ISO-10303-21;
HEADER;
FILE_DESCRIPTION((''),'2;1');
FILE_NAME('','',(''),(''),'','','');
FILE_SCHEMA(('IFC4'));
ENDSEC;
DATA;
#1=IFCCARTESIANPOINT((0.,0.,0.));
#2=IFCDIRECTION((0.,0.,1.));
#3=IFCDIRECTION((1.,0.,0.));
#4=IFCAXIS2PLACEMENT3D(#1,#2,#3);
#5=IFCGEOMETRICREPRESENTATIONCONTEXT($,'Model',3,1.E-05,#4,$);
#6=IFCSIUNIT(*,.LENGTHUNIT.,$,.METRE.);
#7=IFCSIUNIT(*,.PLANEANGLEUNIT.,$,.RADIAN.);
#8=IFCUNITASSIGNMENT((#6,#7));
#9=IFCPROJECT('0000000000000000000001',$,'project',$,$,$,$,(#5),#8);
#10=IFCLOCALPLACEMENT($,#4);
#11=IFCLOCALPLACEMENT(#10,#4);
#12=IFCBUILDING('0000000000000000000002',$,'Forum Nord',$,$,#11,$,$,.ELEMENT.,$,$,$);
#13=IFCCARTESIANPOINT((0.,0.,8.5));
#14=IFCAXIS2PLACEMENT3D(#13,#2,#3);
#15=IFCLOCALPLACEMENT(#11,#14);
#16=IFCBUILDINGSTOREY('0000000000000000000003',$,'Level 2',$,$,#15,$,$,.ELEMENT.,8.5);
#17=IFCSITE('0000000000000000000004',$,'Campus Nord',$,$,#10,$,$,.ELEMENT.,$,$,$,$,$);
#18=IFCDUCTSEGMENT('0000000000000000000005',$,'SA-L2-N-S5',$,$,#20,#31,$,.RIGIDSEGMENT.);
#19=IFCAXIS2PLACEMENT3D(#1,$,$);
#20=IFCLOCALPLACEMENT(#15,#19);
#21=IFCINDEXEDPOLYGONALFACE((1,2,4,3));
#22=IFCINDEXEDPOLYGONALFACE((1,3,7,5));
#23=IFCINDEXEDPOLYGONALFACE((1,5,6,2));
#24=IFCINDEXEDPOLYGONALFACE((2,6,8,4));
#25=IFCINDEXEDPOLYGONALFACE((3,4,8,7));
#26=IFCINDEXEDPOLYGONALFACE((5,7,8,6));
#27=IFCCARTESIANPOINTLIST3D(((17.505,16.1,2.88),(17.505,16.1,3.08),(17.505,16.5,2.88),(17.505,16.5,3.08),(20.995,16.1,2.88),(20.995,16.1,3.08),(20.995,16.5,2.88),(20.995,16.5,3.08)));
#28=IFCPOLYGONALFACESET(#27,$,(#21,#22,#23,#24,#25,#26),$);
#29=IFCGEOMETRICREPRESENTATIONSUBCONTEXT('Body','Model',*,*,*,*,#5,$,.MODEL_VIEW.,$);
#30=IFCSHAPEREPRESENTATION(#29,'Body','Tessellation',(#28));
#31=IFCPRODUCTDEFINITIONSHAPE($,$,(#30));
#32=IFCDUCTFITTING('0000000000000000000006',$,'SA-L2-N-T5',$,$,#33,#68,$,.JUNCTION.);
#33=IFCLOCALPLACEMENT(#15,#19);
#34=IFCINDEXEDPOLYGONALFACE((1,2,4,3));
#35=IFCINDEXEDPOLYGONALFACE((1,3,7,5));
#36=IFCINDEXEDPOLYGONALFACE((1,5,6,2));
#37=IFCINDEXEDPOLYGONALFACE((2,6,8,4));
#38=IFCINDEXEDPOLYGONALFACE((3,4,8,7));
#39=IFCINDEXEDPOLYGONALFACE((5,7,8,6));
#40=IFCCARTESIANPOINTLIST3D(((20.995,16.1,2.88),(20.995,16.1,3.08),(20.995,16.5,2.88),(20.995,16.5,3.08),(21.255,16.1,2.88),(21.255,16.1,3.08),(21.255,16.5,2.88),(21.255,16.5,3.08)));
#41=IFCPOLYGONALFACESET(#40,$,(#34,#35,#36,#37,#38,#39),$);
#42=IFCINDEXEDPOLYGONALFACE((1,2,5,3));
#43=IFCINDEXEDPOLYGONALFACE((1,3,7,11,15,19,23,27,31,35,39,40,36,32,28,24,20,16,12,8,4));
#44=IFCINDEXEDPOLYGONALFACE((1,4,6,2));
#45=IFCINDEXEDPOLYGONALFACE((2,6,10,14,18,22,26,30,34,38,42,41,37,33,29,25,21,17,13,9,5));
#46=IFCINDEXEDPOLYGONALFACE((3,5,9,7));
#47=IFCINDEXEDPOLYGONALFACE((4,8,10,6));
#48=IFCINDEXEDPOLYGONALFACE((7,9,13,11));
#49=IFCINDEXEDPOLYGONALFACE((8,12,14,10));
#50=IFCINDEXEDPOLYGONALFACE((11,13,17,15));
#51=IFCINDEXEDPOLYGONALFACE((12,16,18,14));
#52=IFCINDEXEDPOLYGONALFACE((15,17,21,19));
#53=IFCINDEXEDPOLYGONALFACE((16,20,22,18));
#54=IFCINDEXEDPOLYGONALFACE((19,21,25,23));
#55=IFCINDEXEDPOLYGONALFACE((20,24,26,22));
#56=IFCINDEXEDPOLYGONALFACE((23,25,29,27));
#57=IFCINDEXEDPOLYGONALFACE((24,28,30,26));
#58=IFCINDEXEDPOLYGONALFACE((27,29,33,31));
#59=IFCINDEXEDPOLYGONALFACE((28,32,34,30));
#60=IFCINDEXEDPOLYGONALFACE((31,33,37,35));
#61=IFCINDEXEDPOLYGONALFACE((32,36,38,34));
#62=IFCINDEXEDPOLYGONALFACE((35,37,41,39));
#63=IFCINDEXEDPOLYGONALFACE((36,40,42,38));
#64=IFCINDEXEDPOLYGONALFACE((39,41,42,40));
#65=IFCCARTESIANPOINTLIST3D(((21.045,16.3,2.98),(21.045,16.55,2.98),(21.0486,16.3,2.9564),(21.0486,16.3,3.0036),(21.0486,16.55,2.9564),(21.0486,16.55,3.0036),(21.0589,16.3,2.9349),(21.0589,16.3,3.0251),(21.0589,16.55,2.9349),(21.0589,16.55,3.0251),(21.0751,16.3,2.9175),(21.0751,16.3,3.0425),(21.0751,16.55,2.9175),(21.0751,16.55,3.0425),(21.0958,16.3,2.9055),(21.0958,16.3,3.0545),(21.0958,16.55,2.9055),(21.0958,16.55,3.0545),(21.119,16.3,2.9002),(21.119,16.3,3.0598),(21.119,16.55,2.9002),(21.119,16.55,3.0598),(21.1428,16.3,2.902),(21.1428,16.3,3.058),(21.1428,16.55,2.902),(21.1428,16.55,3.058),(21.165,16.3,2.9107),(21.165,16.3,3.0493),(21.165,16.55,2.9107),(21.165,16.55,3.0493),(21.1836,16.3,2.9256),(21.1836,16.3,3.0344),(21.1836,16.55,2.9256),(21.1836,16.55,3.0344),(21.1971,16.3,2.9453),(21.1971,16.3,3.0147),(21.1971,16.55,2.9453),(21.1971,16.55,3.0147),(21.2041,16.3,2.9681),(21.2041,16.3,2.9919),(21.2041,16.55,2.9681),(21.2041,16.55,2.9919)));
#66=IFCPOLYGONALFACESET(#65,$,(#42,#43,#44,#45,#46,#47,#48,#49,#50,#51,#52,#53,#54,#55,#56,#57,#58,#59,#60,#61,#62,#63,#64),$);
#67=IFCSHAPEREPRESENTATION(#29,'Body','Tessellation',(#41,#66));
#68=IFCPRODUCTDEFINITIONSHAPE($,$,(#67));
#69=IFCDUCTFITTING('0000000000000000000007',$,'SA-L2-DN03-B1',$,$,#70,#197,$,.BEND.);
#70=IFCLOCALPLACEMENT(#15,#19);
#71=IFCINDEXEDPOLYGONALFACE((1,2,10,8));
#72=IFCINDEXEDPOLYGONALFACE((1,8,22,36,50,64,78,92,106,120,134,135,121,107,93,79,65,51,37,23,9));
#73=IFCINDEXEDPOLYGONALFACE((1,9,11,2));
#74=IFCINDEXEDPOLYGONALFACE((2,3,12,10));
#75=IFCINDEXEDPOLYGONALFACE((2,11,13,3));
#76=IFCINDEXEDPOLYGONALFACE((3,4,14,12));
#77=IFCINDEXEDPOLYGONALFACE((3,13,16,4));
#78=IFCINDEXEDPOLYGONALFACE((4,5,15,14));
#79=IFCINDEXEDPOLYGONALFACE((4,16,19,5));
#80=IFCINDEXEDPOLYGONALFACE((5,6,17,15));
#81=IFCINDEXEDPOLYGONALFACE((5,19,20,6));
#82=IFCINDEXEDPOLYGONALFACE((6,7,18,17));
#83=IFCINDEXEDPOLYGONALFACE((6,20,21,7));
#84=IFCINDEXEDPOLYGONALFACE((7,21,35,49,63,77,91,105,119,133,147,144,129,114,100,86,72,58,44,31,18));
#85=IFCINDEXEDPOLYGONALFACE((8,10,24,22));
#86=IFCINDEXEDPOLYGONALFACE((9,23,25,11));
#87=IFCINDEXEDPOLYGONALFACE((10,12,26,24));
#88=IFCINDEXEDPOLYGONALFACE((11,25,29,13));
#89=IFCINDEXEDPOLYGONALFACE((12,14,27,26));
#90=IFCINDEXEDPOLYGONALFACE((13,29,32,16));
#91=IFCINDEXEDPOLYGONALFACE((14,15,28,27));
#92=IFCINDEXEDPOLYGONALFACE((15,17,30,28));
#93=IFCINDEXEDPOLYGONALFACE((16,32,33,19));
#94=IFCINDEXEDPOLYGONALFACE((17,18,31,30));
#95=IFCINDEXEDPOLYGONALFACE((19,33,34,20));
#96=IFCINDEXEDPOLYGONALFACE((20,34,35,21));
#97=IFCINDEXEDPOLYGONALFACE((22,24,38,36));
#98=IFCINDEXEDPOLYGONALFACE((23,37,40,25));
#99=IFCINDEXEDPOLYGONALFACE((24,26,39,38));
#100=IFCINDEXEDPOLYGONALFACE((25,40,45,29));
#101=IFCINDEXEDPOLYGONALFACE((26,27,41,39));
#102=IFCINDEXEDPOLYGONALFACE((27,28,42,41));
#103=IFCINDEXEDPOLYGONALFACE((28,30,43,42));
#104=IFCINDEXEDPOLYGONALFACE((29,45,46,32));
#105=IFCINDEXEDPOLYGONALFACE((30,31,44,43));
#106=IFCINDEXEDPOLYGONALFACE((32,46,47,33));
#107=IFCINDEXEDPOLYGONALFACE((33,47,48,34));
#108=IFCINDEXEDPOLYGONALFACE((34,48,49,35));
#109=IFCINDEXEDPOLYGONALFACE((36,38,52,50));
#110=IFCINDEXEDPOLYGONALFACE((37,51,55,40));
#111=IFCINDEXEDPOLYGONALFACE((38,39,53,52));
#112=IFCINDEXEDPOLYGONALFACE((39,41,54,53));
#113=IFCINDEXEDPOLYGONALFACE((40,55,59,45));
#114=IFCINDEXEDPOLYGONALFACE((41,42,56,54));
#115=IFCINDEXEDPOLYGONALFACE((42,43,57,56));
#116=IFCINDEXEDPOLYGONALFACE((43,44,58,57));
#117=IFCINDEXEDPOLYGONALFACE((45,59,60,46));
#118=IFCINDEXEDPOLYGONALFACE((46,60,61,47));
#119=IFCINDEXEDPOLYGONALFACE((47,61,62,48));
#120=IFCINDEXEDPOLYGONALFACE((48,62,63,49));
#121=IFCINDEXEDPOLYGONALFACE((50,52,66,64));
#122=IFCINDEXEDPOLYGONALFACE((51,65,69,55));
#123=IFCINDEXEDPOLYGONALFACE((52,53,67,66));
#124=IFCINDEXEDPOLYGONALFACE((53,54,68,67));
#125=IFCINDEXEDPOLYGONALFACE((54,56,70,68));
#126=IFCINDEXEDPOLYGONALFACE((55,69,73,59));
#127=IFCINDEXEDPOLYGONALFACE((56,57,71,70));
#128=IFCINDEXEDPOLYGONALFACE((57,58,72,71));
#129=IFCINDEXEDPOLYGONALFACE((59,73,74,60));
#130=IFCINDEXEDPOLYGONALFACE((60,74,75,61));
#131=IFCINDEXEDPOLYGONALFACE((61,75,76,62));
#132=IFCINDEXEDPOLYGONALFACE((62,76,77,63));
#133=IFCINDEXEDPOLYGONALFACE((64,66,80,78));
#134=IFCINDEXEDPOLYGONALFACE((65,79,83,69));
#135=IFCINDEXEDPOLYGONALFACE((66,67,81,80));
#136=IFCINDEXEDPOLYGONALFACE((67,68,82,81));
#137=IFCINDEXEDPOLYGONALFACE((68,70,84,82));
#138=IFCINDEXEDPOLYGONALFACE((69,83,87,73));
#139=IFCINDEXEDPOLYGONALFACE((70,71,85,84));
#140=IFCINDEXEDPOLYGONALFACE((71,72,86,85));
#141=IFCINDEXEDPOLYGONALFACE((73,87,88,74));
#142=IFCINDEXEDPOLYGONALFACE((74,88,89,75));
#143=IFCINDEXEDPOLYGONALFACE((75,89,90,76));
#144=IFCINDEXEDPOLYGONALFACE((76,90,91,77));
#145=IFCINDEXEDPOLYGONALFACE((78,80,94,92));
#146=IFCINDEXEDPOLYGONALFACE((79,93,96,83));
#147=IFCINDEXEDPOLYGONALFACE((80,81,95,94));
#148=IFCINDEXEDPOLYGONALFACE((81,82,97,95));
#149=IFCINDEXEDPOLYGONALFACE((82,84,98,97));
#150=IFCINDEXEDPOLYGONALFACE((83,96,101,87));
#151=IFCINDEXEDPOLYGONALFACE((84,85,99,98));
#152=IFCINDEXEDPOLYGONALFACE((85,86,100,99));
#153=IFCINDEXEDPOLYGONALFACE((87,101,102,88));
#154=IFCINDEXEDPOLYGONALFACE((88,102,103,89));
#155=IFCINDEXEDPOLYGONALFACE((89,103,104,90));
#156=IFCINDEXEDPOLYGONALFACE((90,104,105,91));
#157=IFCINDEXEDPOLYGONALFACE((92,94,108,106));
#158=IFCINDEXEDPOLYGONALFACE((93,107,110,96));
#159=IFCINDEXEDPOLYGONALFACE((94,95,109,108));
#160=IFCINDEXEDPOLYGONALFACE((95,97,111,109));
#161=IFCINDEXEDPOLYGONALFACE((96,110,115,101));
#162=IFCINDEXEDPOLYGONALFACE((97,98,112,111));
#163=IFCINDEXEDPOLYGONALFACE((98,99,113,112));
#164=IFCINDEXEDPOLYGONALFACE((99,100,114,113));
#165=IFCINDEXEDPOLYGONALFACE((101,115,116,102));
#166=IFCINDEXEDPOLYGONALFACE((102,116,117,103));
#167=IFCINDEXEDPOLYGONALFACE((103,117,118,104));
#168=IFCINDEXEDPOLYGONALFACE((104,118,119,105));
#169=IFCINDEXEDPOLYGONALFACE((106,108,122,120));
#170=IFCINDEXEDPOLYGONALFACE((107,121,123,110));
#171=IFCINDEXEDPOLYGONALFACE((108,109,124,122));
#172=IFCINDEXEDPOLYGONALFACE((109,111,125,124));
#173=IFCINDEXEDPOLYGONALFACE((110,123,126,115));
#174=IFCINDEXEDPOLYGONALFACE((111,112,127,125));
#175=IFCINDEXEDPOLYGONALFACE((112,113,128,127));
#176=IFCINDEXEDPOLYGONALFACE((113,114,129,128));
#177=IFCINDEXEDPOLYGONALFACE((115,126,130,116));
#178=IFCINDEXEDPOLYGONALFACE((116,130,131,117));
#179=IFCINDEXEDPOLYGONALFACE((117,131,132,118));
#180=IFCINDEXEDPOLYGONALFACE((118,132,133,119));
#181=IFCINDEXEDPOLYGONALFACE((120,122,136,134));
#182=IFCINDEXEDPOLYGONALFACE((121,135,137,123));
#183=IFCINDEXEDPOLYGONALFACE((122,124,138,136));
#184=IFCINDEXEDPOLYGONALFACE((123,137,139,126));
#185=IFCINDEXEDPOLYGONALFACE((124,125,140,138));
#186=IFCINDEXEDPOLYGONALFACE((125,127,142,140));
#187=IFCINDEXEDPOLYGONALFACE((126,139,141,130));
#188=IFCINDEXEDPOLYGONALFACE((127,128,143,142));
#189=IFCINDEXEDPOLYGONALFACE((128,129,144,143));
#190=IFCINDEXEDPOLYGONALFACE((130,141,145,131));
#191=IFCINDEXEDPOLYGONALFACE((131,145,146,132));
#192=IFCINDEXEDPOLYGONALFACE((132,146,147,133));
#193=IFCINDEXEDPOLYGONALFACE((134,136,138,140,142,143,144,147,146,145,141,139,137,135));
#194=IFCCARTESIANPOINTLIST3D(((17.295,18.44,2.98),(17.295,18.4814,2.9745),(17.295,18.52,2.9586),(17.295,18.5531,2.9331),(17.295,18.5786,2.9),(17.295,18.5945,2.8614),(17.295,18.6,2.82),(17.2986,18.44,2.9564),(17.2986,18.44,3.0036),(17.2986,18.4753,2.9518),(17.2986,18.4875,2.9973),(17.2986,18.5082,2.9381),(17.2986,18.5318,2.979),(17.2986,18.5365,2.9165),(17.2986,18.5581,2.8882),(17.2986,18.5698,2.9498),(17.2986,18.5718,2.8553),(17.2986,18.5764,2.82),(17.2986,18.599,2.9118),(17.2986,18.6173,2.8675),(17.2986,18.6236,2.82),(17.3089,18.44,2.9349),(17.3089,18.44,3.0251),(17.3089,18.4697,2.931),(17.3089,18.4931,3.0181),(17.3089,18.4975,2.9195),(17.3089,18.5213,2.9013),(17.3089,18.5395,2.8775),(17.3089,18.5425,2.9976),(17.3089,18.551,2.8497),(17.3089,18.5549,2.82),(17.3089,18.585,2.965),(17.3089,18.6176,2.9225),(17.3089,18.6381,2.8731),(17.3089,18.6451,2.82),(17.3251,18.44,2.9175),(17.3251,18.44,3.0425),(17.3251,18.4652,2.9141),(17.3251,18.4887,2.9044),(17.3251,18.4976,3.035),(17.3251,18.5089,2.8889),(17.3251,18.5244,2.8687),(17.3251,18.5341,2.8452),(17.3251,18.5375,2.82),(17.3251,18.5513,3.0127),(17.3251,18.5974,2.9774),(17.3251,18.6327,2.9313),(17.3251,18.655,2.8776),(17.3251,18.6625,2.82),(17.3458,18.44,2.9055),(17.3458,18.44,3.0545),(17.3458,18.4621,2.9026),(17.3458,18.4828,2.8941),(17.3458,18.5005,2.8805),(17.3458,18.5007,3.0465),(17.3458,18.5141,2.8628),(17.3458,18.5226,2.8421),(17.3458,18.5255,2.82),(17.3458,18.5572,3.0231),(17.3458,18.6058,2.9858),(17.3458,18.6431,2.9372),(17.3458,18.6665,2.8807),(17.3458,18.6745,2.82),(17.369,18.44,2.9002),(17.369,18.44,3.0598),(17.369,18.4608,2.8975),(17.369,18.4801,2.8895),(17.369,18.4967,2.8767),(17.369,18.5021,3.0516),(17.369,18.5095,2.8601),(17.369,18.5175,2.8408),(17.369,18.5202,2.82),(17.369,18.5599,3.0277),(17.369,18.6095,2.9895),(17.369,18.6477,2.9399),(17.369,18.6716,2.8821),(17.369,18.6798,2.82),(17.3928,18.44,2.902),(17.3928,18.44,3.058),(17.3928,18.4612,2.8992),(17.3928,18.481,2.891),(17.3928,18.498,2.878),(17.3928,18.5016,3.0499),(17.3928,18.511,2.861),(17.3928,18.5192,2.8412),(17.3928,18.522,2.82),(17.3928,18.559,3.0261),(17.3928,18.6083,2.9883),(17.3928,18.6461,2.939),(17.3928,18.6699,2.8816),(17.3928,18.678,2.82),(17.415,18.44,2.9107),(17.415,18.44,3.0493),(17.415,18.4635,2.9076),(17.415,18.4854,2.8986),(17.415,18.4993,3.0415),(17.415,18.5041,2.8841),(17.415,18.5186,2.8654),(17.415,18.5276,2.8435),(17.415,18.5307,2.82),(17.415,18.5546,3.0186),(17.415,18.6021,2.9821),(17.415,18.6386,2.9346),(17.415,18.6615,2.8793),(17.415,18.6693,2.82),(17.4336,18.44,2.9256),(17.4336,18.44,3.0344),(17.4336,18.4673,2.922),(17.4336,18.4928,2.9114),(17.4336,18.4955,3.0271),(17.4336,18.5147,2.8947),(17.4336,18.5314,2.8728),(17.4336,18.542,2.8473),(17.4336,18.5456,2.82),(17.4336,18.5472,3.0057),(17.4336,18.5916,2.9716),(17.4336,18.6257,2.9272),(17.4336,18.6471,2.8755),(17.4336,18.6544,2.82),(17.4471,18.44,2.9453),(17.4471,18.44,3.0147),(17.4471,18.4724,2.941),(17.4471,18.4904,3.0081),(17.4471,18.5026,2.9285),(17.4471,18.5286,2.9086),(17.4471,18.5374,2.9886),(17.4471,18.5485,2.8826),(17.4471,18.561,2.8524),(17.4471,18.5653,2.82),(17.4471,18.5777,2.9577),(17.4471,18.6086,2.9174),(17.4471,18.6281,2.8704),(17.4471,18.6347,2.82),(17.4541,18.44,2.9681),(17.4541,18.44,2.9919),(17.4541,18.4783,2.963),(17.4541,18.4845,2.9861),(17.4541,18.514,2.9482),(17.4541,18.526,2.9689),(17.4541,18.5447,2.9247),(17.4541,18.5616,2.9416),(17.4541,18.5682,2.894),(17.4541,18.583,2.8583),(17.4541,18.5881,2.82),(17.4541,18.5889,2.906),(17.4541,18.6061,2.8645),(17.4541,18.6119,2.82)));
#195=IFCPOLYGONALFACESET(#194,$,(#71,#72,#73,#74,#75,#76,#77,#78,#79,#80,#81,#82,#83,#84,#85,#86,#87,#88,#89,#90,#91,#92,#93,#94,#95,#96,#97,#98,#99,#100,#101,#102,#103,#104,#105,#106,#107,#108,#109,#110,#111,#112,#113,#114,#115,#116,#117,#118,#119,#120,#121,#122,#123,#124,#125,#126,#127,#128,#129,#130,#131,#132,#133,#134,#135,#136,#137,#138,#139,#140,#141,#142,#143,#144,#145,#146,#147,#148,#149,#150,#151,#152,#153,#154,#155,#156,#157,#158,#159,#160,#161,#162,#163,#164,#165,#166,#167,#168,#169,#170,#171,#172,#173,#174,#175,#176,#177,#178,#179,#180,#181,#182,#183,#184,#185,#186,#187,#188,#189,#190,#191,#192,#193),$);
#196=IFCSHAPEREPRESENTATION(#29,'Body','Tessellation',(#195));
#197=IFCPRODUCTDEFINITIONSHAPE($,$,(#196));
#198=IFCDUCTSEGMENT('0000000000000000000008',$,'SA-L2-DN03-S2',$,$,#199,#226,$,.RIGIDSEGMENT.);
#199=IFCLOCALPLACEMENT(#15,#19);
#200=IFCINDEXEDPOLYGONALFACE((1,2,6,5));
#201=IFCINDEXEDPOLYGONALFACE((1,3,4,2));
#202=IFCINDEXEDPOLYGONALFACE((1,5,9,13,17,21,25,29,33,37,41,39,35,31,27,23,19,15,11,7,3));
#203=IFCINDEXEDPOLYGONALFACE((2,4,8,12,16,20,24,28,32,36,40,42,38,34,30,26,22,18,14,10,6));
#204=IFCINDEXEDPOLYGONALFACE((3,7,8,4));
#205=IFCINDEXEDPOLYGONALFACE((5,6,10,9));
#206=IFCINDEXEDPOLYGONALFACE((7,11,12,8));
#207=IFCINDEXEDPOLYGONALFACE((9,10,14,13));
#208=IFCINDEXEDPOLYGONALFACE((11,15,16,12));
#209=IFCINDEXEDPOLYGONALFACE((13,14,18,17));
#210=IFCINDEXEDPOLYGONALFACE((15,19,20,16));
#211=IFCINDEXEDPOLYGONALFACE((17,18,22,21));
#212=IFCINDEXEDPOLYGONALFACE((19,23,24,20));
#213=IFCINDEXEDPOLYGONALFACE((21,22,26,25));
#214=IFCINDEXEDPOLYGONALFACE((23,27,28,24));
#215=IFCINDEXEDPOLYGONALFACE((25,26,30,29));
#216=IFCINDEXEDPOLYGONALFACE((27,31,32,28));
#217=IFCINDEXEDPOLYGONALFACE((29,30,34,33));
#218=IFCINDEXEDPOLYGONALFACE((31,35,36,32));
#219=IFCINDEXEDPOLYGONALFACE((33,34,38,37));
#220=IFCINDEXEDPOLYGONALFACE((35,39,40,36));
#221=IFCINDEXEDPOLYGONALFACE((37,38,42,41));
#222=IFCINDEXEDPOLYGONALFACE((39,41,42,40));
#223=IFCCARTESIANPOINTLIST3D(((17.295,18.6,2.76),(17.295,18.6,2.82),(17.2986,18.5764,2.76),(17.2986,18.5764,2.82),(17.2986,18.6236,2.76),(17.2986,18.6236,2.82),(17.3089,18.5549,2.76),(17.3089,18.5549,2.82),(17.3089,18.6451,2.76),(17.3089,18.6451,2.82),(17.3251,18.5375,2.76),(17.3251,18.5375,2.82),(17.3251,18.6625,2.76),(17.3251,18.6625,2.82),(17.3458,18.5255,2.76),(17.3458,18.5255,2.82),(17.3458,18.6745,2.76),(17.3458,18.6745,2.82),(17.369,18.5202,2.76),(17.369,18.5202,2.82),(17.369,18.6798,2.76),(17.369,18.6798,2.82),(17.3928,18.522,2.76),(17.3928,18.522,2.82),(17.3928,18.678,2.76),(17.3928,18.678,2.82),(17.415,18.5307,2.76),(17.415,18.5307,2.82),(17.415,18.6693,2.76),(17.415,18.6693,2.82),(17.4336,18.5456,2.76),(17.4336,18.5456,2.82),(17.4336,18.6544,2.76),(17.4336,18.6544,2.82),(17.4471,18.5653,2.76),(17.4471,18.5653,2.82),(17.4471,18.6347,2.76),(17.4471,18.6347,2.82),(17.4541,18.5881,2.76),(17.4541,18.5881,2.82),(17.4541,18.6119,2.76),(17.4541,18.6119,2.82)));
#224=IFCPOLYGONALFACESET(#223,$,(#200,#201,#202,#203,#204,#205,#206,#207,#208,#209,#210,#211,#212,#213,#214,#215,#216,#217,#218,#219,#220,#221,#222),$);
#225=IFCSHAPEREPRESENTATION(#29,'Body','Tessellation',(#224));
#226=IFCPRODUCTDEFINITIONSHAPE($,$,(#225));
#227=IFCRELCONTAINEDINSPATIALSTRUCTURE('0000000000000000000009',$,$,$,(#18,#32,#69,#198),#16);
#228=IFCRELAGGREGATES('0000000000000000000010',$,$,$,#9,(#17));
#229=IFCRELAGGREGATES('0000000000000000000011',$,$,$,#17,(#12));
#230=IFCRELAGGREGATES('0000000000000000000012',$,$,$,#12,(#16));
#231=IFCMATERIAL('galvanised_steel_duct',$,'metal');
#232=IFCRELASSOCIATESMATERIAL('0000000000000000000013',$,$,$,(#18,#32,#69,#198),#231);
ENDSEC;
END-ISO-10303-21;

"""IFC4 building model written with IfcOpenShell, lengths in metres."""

from ifc_helpers import new_model, entity, si_unit, frame, origin_with_axes, origin_2d_with_axis, place, context, subcontext, project, spatial, rectangle, circle, extrude, material, element, save


model = new_model("IFC4")

# Units and contexts
model_context = context("Model", 3, precision=1e-05, world=origin_with_axes())
body_context = subcontext(model_context, "Body", "Model", "MODEL_VIEW")
ifc_project = project(units=[si_unit("LENGTHUNIT", "METRE"), si_unit("PLANEANGLEUNIT", "RADIAN")], contexts=[model_context])

# Site, building, storey
site_placement = place(None, origin_with_axes())
site = spatial("IfcSite", under=ifc_project, at=site_placement, Name="Campus Nord", CompositionType="ELEMENT")
building_placement = place(site_placement, origin_with_axes())
building = spatial("IfcBuilding", under=site, at=building_placement, Name="Forum Nord", CompositionType="ELEMENT")
storey_placement = place(building_placement, frame((0.0, 0.0, 8.5), z_axis=(0.0, 0.0, 1.0), x_axis=(1.0, 0.0, 0.0)))
storey = spatial("IfcBuildingStorey", under=building, at=storey_placement, Name="Level 2", CompositionType="ELEMENT", Elevation=8.5)

# Duct segment
ifc_material_1 = material(Name="galvanised_steel_duct", Category="metal")
duct_segment_1_placement = place(storey_placement, frame((17.505, 16.3, 2.98), z_axis=(1.0, 0.0, 0.0), x_axis=(0.0, 1.0, 0.0)))
element("IfcDuctSegment", 1, at=duct_segment_1_placement, inside=storey, material=ifc_material_1, Name="SA-L2-N-S5", PredefinedType="RIGIDSEGMENT", context=body_context, shape_type="SweptSolid", body=[
    extrude(rectangle(XDim=0.4, YDim=0.2, at=origin_2d_with_axis()), origin_with_axes(), (0.0, 0.0, 1.0), 3.49),
])

# Duct fittings
duct_fitting_1_placement = place(storey_placement, frame((20.995, 16.3, 2.98), z_axis=(1.0, 0.0, 0.0), x_axis=(0.0, 1.0, 0.0)))
element("IfcDuctFitting", 2, at=duct_fitting_1_placement, inside=storey, material=ifc_material_1, Name="SA-L2-N-T5", PredefinedType="JUNCTION", context=body_context, shape_type="SweptSolid", body=[
    extrude(rectangle(XDim=0.4, YDim=0.2, at=origin_2d_with_axis()), origin_with_axes(), (0.0, 0.0, 1.0), 0.26),
    extrude(circle(Radius=0.08, at=origin_2d_with_axis()), frame((0.0, 0.0, 0.13), z_axis=(1.0, 0.0, 0.0), x_axis=(0.0, 0.0, -1.0)), (0.0, 0.0, 1.0), 0.25),
])
duct_fitting_2_placement = place(storey_placement, frame((17.375, 18.44, 2.98), z_axis=(0.0, 1.0, 0.0), x_axis=(-1.0, 0.0, 0.0)))
ifc_direction_1 = entity("IfcDirection", [1.0, 0.0, 0.0])
element("IfcDuctFitting", 3, at=duct_fitting_2_placement, inside=storey, material=ifc_material_1, Name="SA-L2-DN03-B1", PredefinedType="BEND", context=body_context, shape_type="SweptSolid", body=[
    entity("IfcRevolvedAreaSolid", entity("IfcCircleProfileDef", "AREA", None, entity("IfcAxis2Placement2D", entity("IfcCartesianPoint", [0.0, 0.0]), entity("IfcDirection", [1.0, 0.0])), 0.08), entity("IfcAxis2Placement3D", entity("IfcCartesianPoint", [0.0, 0.0, 0.0]), entity("IfcDirection", [0.0, 0.0, 1.0]), ifc_direction_1), entity("IfcAxis1Placement", entity("IfcCartesianPoint", [0.0, -0.16, 0.0]), ifc_direction_1), 1.5708),
])

# Duct segment
duct_segment_2_placement = place(storey_placement, frame((17.375, 18.6, 2.82), z_axis=(0.0, 0.0, -1.0), x_axis=(-1.0, 0.0, 0.0)))
element("IfcDuctSegment", 4, at=duct_segment_2_placement, inside=storey, material=ifc_material_1, Name="SA-L2-DN03-S2", PredefinedType="RIGIDSEGMENT", context=body_context, shape_type="SweptSolid", body=[
    extrude(circle(Radius=0.08, at=origin_2d_with_axis()), origin_with_axes(), (0.0, 0.0, 1.0), 0.06),
])

save(model, "model.ifc")
